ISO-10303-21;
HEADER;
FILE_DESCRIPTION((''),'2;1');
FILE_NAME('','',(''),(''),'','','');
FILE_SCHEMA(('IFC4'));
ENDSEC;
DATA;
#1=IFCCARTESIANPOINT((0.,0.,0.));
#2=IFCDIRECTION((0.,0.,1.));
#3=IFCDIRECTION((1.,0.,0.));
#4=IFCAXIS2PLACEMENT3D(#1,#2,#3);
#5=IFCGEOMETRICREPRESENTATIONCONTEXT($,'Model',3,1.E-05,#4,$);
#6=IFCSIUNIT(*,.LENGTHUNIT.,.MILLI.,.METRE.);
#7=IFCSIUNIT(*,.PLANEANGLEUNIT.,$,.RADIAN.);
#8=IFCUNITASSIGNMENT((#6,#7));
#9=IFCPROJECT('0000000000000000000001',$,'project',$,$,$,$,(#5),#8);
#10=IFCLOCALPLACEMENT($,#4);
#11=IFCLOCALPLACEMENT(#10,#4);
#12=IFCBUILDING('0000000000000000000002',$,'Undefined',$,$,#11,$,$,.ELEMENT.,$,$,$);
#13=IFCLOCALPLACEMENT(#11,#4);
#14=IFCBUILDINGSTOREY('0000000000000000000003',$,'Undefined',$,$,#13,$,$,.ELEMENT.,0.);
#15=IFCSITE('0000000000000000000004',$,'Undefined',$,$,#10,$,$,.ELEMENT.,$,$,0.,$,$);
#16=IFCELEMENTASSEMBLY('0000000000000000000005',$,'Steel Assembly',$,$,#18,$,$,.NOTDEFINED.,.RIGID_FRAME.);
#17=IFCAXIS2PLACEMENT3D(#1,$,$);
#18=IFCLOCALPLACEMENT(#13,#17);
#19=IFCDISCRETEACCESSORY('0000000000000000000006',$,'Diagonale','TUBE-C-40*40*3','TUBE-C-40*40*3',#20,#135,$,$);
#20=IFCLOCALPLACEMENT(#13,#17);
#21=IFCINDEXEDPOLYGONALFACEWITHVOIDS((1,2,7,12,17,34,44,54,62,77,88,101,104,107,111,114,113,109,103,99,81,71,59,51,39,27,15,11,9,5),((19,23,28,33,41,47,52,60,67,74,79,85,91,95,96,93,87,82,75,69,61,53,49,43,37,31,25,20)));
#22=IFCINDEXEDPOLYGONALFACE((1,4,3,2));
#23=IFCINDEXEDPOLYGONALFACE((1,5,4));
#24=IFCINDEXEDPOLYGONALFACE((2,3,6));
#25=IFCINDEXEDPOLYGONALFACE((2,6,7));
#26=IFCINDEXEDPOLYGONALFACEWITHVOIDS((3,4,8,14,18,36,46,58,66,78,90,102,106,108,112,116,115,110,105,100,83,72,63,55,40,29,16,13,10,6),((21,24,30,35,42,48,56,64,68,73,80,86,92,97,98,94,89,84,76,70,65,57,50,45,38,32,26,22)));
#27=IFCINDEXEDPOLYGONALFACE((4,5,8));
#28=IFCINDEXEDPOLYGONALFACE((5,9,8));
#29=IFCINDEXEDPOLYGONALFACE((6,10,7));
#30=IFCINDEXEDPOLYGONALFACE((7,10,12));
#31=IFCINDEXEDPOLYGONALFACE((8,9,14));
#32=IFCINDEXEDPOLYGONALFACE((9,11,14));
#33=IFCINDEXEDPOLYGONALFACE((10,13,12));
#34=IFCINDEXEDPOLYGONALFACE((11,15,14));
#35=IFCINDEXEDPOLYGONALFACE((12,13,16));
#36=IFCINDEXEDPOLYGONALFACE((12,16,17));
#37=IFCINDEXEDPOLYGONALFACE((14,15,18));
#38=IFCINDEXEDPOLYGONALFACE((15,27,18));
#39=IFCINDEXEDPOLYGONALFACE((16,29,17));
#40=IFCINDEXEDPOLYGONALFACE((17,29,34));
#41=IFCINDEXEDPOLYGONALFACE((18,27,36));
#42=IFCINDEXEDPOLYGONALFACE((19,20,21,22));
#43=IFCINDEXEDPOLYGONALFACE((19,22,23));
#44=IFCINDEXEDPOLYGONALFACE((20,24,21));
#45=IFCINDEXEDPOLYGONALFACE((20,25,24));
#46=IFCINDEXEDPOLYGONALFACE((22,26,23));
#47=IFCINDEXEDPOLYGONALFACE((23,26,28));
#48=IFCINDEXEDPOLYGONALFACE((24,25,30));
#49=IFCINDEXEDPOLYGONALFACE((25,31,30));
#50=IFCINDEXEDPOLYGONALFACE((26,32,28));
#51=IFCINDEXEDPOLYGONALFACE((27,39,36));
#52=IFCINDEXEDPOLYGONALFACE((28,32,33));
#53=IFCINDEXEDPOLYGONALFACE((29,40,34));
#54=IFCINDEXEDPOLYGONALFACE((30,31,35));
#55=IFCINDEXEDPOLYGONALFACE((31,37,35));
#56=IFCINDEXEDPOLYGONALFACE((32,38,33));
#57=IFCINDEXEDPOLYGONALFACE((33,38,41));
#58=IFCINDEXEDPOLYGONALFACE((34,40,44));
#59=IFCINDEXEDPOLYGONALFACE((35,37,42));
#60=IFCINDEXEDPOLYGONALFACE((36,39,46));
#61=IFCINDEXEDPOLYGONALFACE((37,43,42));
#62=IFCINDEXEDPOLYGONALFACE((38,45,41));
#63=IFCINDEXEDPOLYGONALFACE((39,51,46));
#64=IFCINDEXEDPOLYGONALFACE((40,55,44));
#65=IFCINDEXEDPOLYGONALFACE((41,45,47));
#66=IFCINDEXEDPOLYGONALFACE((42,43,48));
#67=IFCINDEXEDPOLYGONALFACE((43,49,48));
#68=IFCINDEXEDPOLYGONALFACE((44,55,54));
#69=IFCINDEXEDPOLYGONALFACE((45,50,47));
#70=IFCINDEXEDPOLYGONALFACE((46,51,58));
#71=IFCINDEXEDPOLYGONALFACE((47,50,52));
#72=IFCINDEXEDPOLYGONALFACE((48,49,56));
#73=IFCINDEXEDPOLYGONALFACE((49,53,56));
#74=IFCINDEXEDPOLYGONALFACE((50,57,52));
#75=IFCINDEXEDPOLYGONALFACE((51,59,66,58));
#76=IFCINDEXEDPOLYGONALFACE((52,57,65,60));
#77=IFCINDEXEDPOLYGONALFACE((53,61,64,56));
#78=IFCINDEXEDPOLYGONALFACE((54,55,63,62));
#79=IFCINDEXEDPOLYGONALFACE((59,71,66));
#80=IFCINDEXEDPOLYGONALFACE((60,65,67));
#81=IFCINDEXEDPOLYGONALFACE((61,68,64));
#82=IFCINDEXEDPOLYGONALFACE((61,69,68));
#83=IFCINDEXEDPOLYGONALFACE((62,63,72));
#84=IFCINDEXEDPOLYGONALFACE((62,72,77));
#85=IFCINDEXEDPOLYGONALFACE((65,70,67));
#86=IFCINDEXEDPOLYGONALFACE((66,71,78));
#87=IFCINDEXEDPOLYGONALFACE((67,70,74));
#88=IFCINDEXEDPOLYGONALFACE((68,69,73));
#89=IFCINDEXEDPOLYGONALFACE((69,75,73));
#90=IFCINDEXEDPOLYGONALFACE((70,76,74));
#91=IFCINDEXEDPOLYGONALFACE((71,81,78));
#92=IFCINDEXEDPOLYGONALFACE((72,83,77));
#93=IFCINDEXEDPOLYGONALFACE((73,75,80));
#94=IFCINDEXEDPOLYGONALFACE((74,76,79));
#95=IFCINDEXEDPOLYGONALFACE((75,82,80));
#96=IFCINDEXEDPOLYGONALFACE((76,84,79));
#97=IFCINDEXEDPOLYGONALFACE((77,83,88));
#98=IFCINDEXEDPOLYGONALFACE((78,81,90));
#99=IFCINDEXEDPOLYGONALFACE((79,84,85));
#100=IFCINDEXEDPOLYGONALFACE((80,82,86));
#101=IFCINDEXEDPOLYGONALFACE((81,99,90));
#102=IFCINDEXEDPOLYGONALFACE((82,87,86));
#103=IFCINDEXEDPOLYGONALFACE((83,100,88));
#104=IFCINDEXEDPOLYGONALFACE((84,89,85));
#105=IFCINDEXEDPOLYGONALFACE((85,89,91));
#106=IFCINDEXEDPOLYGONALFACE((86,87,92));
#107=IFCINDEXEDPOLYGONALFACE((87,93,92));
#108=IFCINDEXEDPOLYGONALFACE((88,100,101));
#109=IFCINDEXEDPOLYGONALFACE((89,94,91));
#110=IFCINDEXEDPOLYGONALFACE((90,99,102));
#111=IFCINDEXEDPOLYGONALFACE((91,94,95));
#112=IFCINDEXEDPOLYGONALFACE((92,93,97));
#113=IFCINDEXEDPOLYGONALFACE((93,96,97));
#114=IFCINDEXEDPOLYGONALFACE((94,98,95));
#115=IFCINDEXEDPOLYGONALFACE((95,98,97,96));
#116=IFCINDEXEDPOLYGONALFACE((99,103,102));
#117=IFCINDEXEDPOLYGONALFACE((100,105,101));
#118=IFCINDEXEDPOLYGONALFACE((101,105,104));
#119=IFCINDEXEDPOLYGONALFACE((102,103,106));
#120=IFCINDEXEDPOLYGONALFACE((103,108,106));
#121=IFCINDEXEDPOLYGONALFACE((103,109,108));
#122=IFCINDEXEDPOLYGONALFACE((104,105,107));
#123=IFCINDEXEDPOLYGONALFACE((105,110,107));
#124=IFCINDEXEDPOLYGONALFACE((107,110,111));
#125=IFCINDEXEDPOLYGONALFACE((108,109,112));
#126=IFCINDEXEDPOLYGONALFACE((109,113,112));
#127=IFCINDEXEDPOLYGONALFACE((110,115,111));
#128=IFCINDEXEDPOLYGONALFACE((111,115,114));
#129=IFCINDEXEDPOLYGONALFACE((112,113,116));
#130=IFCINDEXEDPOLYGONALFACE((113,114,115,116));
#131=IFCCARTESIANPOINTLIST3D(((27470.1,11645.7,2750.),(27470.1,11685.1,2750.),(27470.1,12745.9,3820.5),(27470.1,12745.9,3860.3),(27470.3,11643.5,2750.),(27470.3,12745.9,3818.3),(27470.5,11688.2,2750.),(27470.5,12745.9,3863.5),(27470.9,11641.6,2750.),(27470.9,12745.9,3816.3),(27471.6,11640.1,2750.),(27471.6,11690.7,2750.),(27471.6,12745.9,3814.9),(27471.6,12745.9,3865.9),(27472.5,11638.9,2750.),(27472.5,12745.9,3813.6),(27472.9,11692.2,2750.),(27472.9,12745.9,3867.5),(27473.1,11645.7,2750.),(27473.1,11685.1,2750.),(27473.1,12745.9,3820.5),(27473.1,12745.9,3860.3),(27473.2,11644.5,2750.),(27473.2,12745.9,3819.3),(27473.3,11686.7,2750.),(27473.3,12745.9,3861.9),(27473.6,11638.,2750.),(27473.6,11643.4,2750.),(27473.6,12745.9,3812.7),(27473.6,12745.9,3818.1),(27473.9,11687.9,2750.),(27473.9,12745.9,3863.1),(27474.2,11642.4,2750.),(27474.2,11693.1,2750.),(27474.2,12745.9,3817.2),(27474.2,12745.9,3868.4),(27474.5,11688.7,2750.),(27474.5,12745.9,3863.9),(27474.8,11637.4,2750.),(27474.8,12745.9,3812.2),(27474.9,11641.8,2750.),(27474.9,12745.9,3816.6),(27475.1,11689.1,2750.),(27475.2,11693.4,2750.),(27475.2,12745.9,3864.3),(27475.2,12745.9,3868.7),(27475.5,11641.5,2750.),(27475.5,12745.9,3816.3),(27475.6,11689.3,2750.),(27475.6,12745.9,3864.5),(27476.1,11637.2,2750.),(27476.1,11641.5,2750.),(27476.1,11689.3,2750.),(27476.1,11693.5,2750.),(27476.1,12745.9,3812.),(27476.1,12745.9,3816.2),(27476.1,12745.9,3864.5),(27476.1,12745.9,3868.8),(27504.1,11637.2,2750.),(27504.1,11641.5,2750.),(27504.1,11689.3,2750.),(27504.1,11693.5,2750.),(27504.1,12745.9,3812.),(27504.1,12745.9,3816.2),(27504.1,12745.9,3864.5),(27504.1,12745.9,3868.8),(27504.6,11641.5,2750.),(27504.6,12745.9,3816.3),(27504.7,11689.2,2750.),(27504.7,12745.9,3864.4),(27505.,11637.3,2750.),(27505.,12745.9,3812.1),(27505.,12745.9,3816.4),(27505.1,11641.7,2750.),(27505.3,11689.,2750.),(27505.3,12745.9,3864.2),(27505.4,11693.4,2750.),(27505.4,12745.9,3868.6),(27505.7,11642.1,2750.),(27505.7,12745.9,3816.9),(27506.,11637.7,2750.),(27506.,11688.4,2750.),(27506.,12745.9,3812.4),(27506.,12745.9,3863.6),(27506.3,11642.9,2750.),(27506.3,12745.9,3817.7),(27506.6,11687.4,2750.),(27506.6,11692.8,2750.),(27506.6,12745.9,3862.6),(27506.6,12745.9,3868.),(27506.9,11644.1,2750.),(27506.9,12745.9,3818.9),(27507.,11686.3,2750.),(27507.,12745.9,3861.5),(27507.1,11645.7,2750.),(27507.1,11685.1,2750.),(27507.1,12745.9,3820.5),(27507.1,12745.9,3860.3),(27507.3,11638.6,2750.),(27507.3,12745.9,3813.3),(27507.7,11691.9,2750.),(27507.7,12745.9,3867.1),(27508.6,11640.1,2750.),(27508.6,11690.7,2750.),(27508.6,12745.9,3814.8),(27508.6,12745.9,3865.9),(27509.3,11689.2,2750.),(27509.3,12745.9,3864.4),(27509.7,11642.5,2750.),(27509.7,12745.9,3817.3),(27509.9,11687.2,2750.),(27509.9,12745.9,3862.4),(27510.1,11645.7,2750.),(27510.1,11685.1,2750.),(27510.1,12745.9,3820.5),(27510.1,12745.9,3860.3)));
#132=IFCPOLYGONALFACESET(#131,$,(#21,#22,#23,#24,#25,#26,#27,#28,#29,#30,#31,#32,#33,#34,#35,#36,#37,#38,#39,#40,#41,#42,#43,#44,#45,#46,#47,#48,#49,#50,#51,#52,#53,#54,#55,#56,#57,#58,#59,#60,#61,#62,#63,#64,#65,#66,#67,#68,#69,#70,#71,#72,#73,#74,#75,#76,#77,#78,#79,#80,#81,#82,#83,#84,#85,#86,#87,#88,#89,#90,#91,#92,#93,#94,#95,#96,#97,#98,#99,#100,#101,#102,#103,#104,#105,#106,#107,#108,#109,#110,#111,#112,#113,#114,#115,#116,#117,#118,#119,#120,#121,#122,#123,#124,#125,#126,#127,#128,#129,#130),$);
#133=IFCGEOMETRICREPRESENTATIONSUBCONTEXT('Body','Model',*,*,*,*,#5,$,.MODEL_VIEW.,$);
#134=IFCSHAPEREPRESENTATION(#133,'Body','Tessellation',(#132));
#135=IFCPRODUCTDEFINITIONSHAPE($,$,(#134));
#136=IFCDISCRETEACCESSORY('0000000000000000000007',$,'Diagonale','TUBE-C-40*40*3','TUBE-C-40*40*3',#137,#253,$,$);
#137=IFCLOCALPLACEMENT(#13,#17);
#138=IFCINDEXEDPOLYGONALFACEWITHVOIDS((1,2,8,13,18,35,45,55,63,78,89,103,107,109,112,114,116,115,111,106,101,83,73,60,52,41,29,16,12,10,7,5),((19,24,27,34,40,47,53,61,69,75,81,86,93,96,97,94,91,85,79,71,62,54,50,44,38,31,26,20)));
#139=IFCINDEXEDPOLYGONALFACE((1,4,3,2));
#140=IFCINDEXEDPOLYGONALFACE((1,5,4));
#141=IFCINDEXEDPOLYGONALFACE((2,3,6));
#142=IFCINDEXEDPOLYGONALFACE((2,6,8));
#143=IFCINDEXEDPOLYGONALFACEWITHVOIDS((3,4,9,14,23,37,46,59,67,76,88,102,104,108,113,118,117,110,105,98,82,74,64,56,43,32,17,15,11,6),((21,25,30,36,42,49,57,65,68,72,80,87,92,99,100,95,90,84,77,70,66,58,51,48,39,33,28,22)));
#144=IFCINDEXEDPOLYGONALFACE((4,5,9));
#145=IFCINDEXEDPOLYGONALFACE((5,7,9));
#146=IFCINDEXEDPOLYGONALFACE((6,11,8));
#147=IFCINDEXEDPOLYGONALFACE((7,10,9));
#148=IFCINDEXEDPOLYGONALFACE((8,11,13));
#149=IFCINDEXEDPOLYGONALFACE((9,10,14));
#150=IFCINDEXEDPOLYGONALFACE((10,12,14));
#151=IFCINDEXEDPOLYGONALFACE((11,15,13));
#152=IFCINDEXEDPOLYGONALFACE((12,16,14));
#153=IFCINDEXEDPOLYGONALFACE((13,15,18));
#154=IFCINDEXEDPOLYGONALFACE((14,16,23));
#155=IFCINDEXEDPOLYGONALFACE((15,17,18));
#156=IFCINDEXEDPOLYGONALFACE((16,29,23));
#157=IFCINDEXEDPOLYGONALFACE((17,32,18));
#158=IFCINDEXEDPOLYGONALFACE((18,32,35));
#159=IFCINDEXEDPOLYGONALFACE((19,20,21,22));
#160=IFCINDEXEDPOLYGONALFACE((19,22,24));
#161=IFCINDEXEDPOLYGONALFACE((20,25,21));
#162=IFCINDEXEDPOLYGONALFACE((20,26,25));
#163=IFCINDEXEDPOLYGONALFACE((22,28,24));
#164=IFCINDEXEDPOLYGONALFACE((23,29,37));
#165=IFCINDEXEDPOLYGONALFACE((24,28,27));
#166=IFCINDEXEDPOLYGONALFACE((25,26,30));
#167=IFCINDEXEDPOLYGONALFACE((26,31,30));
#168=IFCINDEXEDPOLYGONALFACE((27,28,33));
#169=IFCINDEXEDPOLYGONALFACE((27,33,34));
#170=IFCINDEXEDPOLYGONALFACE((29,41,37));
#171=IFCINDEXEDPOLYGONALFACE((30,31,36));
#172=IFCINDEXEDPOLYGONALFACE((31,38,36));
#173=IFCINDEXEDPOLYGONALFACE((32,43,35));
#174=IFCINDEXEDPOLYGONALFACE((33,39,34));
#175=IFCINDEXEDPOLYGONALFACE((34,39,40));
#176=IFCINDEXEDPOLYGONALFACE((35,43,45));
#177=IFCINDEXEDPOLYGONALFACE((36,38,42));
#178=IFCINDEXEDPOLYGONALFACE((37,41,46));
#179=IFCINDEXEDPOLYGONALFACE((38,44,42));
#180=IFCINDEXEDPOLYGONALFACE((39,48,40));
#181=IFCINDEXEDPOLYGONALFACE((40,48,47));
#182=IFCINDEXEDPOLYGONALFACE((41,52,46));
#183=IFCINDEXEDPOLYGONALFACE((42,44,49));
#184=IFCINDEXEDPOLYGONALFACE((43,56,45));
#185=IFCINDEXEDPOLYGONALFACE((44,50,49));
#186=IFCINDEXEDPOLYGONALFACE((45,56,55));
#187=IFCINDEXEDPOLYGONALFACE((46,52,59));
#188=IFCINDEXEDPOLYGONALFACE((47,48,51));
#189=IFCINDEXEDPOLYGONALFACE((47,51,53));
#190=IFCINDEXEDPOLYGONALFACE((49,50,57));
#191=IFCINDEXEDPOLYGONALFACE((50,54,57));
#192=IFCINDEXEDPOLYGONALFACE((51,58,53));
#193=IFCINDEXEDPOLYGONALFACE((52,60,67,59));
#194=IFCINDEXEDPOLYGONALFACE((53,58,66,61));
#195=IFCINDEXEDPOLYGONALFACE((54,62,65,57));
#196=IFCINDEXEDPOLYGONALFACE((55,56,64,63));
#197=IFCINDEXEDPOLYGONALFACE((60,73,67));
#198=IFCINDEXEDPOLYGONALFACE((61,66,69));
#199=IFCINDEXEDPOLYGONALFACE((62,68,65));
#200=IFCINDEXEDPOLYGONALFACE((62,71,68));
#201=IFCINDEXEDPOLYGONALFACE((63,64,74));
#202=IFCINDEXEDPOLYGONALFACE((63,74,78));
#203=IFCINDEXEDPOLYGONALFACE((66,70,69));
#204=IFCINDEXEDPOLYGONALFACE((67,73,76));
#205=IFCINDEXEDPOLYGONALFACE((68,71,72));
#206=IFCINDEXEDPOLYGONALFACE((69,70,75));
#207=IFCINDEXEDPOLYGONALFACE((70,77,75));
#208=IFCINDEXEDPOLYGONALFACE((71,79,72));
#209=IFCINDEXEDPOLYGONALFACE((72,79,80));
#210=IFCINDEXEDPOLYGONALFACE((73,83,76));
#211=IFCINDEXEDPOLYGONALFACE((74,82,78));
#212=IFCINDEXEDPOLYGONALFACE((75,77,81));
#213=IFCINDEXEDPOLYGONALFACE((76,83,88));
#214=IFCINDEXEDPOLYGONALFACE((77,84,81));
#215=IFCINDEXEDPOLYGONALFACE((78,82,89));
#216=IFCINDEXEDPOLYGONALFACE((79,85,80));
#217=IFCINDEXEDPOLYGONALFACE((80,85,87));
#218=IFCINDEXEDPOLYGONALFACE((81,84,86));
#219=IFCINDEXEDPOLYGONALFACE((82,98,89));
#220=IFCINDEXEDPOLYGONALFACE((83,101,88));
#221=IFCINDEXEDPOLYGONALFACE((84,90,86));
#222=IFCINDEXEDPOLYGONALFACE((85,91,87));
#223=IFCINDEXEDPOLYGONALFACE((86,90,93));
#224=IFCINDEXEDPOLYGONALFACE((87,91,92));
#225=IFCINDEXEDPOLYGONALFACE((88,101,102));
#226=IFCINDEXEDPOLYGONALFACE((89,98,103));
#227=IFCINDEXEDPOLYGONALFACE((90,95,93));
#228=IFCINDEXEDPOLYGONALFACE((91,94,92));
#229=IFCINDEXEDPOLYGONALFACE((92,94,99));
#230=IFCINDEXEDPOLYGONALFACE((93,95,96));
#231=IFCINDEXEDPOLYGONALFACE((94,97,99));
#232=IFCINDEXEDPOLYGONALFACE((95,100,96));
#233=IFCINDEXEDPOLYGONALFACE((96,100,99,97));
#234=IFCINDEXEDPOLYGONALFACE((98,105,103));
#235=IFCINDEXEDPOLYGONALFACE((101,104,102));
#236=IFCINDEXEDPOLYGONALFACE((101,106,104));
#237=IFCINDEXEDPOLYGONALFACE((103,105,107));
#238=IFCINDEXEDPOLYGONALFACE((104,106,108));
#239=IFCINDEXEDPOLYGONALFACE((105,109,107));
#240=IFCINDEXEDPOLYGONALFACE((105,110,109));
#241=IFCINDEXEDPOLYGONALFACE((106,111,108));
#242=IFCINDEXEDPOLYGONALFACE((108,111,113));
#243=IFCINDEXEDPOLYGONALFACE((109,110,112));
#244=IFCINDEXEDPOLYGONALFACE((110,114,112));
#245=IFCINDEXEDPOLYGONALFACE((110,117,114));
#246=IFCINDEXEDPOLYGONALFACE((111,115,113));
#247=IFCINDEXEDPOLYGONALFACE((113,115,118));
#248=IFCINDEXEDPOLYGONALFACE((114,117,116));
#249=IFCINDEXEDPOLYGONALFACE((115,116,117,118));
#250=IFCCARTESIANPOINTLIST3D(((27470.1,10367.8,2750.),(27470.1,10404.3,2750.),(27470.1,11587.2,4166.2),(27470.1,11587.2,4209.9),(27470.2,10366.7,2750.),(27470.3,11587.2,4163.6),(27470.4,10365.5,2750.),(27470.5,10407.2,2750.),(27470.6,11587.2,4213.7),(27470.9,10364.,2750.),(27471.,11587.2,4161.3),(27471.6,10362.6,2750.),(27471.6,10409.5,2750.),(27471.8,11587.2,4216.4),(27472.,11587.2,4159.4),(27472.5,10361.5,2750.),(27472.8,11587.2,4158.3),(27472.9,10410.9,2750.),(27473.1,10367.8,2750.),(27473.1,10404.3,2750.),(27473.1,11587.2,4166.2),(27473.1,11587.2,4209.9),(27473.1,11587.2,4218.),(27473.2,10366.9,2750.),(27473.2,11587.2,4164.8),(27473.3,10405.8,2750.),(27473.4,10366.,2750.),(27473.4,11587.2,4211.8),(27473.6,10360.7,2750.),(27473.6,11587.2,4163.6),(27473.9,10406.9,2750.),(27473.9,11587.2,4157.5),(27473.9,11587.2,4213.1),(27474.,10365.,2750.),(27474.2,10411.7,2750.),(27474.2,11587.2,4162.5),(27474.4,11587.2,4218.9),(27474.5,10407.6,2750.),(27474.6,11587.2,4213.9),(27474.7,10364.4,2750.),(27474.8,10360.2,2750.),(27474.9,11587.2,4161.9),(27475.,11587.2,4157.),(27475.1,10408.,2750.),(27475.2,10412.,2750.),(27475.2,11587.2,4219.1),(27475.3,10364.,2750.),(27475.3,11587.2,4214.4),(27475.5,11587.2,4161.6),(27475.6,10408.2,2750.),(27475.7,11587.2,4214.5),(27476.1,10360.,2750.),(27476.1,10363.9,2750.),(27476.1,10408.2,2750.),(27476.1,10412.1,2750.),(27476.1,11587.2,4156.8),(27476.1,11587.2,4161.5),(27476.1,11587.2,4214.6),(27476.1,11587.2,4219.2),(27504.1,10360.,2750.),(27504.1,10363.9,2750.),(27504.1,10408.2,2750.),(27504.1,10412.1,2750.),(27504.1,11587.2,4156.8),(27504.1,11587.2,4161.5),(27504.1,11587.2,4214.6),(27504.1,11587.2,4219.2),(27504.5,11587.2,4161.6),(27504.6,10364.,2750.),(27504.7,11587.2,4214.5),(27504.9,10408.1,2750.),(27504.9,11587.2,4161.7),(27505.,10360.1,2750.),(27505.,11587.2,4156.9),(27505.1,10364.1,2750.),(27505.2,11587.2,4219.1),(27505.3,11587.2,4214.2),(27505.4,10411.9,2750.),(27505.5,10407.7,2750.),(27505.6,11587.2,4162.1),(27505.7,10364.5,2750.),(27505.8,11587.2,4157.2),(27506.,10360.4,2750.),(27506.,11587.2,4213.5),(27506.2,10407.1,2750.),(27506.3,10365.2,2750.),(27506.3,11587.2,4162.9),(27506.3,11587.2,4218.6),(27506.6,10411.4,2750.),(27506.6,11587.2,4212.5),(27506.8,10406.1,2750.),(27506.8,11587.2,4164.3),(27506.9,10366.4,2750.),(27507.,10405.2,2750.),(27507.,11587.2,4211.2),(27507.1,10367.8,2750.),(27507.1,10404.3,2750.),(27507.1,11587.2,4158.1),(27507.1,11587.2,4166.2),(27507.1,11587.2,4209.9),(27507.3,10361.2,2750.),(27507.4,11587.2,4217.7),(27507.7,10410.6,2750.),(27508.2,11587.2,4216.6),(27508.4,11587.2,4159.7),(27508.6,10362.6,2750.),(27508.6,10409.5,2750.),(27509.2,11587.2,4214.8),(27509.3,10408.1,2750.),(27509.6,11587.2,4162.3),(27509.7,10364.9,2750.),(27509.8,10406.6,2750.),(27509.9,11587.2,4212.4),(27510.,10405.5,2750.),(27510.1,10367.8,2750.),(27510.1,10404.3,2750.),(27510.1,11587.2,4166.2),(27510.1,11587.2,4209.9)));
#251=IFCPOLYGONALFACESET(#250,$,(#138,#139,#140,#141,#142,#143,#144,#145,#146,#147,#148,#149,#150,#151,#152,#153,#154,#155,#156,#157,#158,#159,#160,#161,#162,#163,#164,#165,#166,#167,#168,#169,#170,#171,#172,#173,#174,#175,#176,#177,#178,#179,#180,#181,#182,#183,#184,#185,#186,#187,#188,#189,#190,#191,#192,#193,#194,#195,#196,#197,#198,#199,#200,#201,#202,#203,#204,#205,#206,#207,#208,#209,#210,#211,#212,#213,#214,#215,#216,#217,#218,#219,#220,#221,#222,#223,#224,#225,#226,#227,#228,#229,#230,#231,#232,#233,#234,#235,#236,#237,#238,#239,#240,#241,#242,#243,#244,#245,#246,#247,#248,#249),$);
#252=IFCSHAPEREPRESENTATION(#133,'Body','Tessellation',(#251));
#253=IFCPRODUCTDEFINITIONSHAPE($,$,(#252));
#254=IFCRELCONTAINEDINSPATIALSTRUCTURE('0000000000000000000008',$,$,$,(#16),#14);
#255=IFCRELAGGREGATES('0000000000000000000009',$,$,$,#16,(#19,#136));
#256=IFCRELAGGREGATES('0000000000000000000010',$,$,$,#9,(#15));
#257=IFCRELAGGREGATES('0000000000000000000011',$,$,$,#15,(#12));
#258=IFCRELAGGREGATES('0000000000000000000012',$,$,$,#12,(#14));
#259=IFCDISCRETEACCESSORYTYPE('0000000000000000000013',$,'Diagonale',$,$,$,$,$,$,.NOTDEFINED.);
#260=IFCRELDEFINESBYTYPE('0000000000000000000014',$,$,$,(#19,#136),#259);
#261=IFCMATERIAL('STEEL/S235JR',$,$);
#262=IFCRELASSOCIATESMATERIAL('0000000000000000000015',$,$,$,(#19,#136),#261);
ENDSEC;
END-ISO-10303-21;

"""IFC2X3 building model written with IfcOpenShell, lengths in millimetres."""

from ifc_helpers import new_model, si_unit, frame, origin_with_axes, origin_2d_with_axis, place, context, subcontext, project, spatial, hollow_rectangle, extrude, clip, halfspace, material, type_object, element, aggregate, save


model = new_model("IFC2X3")

# Units and contexts
model_context = context("Model", 3, precision=1e-05, world=origin_with_axes())
body_context = subcontext(model_context, "Body", "Model", "MODEL_VIEW")
ifc_project = project(units=[si_unit("LENGTHUNIT", "METRE", prefix="MILLI"), si_unit("PLANEANGLEUNIT", "RADIAN")], contexts=[model_context])

# Site, building, storey
site_placement = place(None, origin_with_axes())
site = spatial("IfcSite", under=ifc_project, at=site_placement, Name="Undefined", CompositionType="ELEMENT", RefElevation=0.0)
building_placement = place(site_placement, origin_with_axes())
building = spatial("IfcBuilding", under=site, at=building_placement, Name="Undefined", CompositionType="ELEMENT")
storey_placement = place(building_placement, origin_with_axes())
storey = spatial("IfcBuildingStorey", under=building, at=storey_placement, Name="Undefined", CompositionType="ELEMENT", Elevation=0.0)

# Element assembly, discrete accessories
assembly_1_placement = place(storey_placement, origin_with_axes())
assembly_1 = element("IfcElementAssembly", 1, at=assembly_1_placement, inside=storey, Name="Steel Assembly", AssemblyPlace="NOTDEFINED", PredefinedType="RIGID_FRAME")
ifc_material_1 = material(Name="STEEL/S235JR")
discrete_accessory_type_1 = type_object("IfcDiscreteAccessoryType", Name="Diagonale")
discrete_accessory_1_placement = place(assembly_1_placement, frame((27490.1, 11651.4, 2735.9), z_axis=(0.0, -0.710321, 0.703878), x_axis=(0.0, 0.703878, 0.710321)))
discrete_accessory_1 = element("IfcDiscreteAccessory", 2, at=discrete_accessory_1_placement, type_object=discrete_accessory_type_1, material=ifc_material_1, Name="Diagonale", Description="TUBE-C-40*40*3", ObjectType="TUBE-C-40*40*3", context=body_context, shape_type="Clipping", body=[
    clip(clip(extrude(hollow_rectangle(XDim=40.0, YDim=40.0, WallThickness=3.0, InnerFilletRadius=3.0, OuterFilletRadius=6.0, at=origin_2d_with_axis()), frame((1595.3, 0.0, 0.0), z_axis=(-1.0, 0.0, 0.0), x_axis=(0.0, -1.0, 0.0)), (0.0, 0.0, 1.0), 1615.9), halfspace(frame((1512.1, 0.0, -42.4), z_axis=(0.703878, 0.0, -0.710321), x_axis=(0.0, -1.0, 0.0)), False)), halfspace(frame((21.0, 0.0, -1.2), z_axis=(-0.710321, 0.0, -0.703878), x_axis=(0.0, -1.0, 0.0)), False)),
])
discrete_accessory_2_placement = place(assembly_1_placement, frame((27490.1, 10375.3, 2737.2), z_axis=(0.0, -0.767483, 0.64107), x_axis=(0.0, 0.64107, 0.767483)))
discrete_accessory_2 = element("IfcDiscreteAccessory", 3, at=discrete_accessory_2_placement, type_object=discrete_accessory_type_1, material=ifc_material_1, Name="Diagonale", Description="TUBE-C-40*40*3", ObjectType="TUBE-C-40*40*3", context=body_context, shape_type="Clipping", body=[
    clip(clip(extrude(hollow_rectangle(XDim=40.0, YDim=40.0, WallThickness=3.0, InnerFilletRadius=3.0, OuterFilletRadius=6.0, at=origin_2d_with_axis()), frame((1931.5, 0.0, 0.0), z_axis=(-1.0, 0.0, 0.0), x_axis=(0.0, -1.0, 0.0)), (0.0, 0.0, 1.0), 1955.8), halfspace(frame((1843.1, 0.0, -39.5), z_axis=(0.64107, 0.0, -0.767483), x_axis=(0.0, -1.0, 0.0)), False)), halfspace(frame((17.2, 0.0, -0.6), z_axis=(-0.767483, 0.0, -0.64107), x_axis=(0.0, -1.0, 0.0)), False)),
])

aggregate(assembly_1, [discrete_accessory_1, discrete_accessory_2])

save(model, "model.ifc")
